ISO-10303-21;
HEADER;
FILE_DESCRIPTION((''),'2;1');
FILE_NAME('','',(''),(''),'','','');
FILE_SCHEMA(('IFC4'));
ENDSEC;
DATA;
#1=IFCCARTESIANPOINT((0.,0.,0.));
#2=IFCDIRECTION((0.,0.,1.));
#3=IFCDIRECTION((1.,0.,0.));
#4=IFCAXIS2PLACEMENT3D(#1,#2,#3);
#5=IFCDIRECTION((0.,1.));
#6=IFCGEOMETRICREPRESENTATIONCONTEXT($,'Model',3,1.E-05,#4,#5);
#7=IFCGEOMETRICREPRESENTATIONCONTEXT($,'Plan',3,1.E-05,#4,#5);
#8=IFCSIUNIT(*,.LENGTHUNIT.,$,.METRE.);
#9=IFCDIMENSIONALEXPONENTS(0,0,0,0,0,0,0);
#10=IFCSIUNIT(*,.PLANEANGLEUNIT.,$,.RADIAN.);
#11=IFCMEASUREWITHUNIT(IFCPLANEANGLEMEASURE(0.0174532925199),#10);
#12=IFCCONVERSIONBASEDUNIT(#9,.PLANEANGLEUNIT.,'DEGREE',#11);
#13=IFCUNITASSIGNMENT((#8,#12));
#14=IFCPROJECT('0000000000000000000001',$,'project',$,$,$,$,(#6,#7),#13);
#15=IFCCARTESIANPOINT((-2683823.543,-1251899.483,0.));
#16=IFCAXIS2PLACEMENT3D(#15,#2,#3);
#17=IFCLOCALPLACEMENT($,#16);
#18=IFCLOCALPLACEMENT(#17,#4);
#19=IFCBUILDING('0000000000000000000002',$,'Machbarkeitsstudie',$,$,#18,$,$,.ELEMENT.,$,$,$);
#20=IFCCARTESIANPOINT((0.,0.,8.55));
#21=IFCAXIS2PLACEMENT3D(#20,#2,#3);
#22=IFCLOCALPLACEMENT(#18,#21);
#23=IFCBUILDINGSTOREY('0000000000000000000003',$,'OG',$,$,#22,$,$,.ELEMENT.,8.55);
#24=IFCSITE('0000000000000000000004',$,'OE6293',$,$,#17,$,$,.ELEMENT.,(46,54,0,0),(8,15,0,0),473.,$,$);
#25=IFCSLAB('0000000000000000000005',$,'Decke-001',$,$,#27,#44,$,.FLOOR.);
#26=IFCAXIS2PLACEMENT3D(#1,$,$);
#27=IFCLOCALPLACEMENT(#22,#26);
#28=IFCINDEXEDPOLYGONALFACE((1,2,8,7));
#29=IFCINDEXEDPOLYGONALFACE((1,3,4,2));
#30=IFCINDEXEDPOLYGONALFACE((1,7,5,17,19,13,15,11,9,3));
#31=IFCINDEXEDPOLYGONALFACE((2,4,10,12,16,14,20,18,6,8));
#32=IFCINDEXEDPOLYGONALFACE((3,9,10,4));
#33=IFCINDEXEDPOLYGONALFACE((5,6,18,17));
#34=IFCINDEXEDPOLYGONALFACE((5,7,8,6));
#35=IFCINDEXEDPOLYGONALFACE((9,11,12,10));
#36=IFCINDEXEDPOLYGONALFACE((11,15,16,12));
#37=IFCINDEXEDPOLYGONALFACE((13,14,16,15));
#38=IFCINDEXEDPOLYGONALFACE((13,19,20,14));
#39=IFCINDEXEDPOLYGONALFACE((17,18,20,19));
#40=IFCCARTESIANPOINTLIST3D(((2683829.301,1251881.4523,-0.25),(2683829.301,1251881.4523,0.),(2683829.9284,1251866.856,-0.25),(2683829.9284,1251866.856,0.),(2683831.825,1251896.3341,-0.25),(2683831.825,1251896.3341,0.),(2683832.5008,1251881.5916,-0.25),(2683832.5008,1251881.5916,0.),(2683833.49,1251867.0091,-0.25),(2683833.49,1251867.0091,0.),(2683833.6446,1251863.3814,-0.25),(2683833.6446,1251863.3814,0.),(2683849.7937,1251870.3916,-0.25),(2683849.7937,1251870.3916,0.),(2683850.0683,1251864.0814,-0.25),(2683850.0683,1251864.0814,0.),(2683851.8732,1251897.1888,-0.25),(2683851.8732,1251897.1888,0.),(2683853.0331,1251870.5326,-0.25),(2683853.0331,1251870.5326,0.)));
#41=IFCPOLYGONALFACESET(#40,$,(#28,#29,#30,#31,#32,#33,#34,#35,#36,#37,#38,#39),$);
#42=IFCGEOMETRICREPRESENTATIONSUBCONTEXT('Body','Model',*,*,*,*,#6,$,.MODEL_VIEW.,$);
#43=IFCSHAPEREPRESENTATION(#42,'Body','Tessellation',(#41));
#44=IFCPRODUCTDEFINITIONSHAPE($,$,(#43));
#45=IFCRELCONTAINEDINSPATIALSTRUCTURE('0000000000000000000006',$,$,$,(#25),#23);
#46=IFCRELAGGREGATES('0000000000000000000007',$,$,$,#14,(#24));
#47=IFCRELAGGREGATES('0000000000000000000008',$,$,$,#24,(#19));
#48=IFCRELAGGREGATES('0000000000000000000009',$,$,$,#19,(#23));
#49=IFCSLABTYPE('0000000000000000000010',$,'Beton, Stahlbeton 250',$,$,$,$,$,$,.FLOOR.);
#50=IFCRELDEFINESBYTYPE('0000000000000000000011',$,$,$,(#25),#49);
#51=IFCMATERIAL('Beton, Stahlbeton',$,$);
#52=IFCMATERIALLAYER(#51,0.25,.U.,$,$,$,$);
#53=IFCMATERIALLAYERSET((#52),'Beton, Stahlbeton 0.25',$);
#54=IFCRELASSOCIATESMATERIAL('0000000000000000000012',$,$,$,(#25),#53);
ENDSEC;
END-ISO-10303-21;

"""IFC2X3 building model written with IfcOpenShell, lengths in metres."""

from ifc_helpers import new_model, entity, si_unit, converted_unit, direction, frame, origin_with_axes, place, context, subcontext, project, spatial, polyline, outline, extrude, material, layer, layer_set, layer_usage, type_object, element, save


model = new_model("IFC2X3")

# Units and contexts
model_context = context("Model", 3, precision=1e-05, world=origin_with_axes(), true_north=direction((0.0, 1.0)))
plan_context = context("Plan", 3, precision=1e-05, world=origin_with_axes(), true_north=direction((0.0, 1.0)))
body_context = subcontext(model_context, "Body", "Model", "MODEL_VIEW")
ifc_project = project(units=[si_unit("LENGTHUNIT", "METRE"), converted_unit("PLANEANGLEUNIT", "DEGREE", entity("IfcPlaneAngleMeasure", 0.0174532925199), si_unit("PLANEANGLEUNIT", "RADIAN"), dimensions=[0, 0, 0, 0, 0, 0, 0])], contexts=[model_context, plan_context])

# Site, building, storey
site_placement = place(None, frame((-2683823.543, -1251899.483, 0.0), z_axis=(0.0, 0.0, 1.0), x_axis=(1.0, 0.0, 0.0)))
site = spatial("IfcSite", under=ifc_project, at=site_placement, Name="OE6293", CompositionType="ELEMENT", RefLatitude=(46, 54, 0, 0), RefLongitude=(8, 15, 0, 0), RefElevation=473.0)
building_placement = place(site_placement, origin_with_axes())
building = spatial("IfcBuilding", under=site, at=building_placement, Name="Machbarkeitsstudie", CompositionType="ELEMENT")
storey_placement = place(building_placement, frame((0.0, 0.0, 8.55), z_axis=(0.0, 0.0, 1.0), x_axis=(1.0, 0.0, 0.0)))
storey = spatial("IfcBuildingStorey", under=building, at=storey_placement, Name="OG", CompositionType="ELEMENT", Elevation=8.55)

# Slab
ifc_material = material(Name="Beton, Stahlbeton")
ifc_layer = layer(ifc_material, 0.25, ventilated="UNKNOWN")
ifc_layer_set = layer_set([ifc_layer], Name="Beton, Stahlbeton 0.25")
ifc_layer_usage = layer_usage(ifc_layer_set, "AXIS3", "NEGATIVE", 0.25)
slab_type = type_object("IfcSlabType", Name="Beton, Stahlbeton 250", PredefinedType="FLOOR")
slab_placement = place(storey_placement, frame((2683832.5008, 1251881.5916, 0.0), z_axis=(0.0, 0.0, 1.0), x_axis=(1.0, 0.0, 0.0)))
element("IfcSlab", 1, at=slab_placement, inside=storey, type_object=slab_type, material=ifc_layer_usage, Name="Decke-001", PredefinedType="FLOOR", context=body_context, shape_type="SweptSolid", body=[
    extrude(outline(polyline([(0.0, 0.0), (-3.1998, -0.1392), (-2.5724, -14.7356), (0.9892, -14.5825), (1.1438, -18.2102), (17.5674, -17.5102), (17.2928, -11.2), (20.5323, -11.059), (19.3724, 15.5972), (-0.6758, 14.7426), (0.0, 0.0)])), frame((0.0, 0.0, -0.25), z_axis=(0.0, 0.0, 1.0), x_axis=(1.0, 0.0, 0.0)), (0.0, 0.0, 1.0), 0.25),
])

save(model, "model.ifc")
